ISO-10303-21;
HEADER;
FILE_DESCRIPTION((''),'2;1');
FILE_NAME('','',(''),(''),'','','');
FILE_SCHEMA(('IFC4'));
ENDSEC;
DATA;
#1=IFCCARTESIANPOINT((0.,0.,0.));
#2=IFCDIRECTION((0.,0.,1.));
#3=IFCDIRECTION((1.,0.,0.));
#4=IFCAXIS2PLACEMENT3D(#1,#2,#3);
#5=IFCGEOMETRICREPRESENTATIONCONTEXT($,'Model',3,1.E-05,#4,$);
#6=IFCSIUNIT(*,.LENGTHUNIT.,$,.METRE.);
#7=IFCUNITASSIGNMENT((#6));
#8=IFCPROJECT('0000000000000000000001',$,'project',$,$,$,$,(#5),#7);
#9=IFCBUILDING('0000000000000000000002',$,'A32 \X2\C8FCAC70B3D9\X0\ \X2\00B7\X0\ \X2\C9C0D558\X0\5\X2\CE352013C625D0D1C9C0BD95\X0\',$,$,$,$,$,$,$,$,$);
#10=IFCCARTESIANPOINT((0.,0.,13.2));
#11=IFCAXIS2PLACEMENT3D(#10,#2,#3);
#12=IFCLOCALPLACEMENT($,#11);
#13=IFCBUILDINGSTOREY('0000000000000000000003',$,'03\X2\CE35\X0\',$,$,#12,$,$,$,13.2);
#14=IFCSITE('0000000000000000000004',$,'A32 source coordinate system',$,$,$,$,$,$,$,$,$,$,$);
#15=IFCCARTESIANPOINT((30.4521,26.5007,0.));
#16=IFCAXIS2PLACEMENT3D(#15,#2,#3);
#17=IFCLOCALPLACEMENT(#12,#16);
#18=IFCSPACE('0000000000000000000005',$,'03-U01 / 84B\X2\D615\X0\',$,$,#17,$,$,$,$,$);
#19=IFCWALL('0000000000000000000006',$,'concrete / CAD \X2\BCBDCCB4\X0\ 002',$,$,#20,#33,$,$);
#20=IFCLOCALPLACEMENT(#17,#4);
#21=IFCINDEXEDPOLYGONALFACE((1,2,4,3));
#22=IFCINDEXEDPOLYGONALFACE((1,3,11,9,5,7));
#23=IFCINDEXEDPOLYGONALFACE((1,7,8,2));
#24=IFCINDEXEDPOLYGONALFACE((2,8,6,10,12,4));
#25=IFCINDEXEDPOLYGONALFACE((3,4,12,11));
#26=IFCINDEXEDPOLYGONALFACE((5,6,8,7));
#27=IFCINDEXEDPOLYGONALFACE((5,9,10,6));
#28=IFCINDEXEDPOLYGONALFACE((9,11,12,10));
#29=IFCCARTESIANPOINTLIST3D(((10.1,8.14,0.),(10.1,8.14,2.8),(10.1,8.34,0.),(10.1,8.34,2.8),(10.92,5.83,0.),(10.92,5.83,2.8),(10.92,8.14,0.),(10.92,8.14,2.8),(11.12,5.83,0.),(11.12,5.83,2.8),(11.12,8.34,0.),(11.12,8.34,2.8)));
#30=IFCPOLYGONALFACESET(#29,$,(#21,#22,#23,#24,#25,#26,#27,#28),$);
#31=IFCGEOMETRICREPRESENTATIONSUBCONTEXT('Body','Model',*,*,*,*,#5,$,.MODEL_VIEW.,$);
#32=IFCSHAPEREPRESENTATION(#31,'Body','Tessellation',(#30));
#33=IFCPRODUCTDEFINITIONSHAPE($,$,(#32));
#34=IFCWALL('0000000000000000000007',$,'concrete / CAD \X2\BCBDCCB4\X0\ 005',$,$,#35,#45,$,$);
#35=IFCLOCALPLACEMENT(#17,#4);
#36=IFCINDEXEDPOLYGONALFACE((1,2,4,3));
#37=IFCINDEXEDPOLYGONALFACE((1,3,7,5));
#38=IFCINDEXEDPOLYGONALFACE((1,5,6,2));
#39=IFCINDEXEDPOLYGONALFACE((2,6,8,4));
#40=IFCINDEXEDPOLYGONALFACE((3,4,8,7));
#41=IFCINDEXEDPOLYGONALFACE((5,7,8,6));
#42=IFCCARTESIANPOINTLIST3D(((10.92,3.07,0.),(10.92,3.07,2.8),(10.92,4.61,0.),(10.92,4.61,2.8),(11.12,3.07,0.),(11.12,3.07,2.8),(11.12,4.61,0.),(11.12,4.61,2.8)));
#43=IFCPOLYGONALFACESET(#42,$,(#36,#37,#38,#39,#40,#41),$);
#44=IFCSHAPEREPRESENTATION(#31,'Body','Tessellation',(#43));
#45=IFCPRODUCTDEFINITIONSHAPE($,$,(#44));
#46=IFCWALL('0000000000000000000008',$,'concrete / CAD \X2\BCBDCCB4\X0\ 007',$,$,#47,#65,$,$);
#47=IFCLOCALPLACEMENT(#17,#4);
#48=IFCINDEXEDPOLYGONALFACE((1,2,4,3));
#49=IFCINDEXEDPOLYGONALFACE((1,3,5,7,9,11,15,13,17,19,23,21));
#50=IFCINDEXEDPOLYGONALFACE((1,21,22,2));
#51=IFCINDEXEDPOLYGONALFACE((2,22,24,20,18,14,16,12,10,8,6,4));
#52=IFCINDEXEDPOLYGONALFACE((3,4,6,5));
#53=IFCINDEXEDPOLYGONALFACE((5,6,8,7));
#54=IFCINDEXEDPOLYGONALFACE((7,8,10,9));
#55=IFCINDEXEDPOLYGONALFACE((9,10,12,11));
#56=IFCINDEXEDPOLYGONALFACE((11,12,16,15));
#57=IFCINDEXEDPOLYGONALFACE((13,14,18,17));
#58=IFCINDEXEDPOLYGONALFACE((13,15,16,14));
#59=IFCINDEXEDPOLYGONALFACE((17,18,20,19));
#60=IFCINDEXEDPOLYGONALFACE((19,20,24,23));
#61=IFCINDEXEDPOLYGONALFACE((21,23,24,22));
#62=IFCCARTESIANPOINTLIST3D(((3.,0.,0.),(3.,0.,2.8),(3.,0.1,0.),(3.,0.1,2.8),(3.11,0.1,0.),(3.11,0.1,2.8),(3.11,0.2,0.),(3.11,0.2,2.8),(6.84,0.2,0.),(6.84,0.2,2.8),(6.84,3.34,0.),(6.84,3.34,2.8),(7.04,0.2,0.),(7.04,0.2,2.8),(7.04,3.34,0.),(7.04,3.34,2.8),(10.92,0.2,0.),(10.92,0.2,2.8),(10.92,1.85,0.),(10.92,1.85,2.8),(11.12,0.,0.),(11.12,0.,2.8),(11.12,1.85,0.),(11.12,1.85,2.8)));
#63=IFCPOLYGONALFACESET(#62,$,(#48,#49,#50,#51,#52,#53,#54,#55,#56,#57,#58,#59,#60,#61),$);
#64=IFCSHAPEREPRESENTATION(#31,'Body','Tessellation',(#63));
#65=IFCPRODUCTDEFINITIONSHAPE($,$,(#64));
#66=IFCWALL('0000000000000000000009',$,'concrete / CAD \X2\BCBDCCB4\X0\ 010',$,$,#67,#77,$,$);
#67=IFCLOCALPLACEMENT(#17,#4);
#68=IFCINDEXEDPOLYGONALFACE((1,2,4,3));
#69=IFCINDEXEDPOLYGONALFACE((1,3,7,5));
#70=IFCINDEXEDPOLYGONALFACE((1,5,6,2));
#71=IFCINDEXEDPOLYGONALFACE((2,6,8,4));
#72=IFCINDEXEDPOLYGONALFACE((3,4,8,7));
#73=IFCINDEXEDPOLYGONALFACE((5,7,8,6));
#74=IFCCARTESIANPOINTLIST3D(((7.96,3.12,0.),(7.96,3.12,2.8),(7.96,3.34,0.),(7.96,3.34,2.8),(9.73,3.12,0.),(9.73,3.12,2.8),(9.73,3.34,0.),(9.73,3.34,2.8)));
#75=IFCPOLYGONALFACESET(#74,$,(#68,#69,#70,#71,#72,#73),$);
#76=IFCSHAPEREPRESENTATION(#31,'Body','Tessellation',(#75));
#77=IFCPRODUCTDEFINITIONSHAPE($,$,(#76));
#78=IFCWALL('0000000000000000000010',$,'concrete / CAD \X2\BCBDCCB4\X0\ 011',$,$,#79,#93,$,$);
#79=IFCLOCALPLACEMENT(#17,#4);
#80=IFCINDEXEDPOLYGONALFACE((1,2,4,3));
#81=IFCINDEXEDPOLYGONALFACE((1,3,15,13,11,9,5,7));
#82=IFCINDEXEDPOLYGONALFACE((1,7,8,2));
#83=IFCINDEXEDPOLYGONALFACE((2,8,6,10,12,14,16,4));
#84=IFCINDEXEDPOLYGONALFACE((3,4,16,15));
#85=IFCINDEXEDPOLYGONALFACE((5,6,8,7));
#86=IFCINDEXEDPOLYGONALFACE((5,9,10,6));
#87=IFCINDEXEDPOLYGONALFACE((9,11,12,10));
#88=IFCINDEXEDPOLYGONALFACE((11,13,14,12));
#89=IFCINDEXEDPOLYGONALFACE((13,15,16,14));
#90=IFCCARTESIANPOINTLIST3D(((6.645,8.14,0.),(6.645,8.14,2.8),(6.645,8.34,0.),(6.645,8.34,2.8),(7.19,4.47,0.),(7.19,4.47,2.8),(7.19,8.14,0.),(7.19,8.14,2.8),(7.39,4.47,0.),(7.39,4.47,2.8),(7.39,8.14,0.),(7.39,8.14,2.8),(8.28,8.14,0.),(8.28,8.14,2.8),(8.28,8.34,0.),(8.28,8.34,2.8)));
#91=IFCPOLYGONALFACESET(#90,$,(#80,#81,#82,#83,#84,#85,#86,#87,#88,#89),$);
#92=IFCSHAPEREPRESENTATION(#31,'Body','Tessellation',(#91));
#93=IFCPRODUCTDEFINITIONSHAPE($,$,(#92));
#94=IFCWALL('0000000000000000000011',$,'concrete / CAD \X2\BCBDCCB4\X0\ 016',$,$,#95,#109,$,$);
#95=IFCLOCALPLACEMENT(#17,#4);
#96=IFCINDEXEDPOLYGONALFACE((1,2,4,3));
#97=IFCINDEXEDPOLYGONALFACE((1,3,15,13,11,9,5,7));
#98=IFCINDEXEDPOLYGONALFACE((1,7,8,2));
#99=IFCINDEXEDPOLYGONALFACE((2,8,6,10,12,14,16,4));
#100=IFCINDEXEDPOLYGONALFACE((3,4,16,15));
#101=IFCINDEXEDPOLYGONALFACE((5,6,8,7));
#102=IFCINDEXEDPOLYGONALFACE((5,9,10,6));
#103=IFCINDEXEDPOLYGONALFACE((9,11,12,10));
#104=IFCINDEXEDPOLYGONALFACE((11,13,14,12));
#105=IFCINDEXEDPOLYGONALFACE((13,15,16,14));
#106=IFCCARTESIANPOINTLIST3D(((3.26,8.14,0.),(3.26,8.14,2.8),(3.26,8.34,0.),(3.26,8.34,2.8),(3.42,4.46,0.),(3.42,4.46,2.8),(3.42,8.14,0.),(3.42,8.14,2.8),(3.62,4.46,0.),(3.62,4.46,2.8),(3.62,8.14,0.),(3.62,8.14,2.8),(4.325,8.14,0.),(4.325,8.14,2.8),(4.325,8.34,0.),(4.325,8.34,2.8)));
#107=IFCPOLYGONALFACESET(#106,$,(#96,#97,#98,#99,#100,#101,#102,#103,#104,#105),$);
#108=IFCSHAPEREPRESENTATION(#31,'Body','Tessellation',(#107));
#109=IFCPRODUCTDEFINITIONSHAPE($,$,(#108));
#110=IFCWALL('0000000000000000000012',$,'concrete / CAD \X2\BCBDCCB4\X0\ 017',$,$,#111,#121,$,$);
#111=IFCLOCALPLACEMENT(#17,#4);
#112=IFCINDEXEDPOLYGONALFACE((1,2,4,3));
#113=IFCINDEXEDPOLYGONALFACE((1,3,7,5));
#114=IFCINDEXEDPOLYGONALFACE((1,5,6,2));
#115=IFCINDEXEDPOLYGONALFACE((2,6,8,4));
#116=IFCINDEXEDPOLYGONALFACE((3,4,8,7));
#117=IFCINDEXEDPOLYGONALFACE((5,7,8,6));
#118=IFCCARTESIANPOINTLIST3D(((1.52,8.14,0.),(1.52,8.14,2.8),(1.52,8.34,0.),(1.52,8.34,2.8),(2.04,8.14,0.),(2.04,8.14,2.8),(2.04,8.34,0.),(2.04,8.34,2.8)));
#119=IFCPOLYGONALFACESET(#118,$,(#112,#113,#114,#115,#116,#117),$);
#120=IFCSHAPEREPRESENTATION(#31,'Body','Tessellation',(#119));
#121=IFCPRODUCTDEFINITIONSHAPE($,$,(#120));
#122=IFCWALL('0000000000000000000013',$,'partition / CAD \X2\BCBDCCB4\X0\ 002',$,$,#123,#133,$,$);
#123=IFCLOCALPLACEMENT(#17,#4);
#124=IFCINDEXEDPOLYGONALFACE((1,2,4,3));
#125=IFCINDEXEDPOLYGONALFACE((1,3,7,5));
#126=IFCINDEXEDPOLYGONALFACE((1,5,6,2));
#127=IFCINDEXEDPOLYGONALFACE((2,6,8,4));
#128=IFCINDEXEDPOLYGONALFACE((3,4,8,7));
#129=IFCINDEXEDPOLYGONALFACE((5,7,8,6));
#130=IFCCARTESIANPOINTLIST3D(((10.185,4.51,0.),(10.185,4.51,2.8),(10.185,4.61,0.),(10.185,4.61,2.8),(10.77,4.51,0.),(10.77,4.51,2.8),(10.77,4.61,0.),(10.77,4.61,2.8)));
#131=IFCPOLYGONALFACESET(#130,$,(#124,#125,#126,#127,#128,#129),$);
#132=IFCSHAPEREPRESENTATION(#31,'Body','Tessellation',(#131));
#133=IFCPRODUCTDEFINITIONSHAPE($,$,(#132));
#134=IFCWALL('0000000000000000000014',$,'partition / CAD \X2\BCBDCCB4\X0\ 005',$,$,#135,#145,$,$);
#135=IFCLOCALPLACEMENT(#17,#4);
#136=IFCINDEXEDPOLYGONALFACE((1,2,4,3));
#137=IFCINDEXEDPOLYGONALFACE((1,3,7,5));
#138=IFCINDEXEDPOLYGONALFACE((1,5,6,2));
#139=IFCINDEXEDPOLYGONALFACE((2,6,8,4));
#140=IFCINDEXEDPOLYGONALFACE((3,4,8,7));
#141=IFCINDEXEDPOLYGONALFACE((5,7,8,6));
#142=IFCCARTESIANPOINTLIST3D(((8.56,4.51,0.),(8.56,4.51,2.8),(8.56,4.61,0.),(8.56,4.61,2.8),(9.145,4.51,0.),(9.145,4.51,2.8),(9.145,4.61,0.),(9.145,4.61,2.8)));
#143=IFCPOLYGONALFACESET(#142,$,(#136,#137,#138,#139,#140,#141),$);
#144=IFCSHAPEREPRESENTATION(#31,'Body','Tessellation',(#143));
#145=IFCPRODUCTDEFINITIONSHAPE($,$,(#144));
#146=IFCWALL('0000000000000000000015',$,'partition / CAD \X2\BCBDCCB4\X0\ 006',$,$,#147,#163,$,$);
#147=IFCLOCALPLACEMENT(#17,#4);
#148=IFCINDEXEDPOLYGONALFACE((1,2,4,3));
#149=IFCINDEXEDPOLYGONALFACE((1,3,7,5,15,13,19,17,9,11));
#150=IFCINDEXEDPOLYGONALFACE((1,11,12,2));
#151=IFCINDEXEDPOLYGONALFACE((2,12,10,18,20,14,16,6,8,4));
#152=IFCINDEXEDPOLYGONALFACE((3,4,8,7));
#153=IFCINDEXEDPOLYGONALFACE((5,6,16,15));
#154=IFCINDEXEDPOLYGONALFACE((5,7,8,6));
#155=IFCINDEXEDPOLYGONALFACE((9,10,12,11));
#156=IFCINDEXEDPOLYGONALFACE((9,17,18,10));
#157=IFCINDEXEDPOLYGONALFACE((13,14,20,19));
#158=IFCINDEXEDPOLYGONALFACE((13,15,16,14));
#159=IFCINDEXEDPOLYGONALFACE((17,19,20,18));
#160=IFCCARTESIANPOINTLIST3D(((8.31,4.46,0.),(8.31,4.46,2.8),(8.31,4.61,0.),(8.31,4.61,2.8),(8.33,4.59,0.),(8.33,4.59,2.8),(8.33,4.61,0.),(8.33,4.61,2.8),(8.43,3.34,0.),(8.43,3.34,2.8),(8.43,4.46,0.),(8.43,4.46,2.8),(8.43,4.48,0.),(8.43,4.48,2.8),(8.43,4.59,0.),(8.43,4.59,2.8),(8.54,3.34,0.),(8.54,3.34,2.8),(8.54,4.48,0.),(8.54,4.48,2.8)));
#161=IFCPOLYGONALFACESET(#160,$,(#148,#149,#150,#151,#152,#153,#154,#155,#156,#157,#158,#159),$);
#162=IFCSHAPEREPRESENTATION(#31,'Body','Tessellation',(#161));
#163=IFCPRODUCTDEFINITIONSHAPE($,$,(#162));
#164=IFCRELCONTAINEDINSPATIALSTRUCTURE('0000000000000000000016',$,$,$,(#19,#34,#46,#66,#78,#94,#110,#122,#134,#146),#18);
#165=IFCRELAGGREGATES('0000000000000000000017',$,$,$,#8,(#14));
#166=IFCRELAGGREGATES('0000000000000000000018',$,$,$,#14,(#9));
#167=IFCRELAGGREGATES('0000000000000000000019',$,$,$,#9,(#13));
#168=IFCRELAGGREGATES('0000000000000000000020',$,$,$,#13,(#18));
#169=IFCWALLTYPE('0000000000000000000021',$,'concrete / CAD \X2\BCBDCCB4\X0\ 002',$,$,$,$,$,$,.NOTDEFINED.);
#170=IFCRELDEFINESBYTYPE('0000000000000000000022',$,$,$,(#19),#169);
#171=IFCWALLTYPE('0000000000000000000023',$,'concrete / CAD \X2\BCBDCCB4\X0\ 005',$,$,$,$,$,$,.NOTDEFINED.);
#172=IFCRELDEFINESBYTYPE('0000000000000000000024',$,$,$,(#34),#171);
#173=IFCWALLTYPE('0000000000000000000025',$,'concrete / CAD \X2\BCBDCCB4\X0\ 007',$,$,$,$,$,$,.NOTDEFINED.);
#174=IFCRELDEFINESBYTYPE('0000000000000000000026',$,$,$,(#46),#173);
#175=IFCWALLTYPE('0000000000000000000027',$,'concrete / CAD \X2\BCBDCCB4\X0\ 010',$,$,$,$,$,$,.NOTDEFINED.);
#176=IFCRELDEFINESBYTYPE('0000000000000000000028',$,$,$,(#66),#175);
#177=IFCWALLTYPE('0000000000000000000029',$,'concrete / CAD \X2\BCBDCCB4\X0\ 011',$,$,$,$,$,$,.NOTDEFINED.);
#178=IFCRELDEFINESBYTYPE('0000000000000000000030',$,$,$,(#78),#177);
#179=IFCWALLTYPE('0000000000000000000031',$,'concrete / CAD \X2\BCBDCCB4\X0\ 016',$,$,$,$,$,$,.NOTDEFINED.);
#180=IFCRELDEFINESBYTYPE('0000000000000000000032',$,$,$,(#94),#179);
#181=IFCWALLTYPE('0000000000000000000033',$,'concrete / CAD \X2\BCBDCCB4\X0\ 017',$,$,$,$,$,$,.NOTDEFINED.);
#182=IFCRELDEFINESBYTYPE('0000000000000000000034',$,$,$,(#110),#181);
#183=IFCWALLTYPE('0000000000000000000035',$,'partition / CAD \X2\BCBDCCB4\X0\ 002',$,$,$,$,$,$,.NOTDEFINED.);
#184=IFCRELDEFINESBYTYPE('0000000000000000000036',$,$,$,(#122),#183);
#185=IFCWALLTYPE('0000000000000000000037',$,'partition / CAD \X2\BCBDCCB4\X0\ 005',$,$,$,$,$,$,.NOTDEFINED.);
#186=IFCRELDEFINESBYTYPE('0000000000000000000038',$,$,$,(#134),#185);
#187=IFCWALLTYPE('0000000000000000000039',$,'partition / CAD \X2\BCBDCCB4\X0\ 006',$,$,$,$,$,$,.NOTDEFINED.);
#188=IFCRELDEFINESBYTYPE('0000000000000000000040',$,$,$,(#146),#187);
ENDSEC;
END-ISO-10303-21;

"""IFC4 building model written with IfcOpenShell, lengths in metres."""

from ifc_helpers import new_model, si_unit, frame, origin, origin_with_axes, place, context, subcontext, project, spatial, polyline, outline, extrude, source, transform, mapped, type_object, type_shapes, element, save


model = new_model("IFC4")

# Units and contexts
model_context = context("Model", 3, precision=1e-05, world=origin_with_axes())
body_context = subcontext(model_context, "Body", "Model", "MODEL_VIEW")
ifc_project = project(units=[si_unit("LENGTHUNIT", "METRE")], contexts=[model_context])

# Site, building, storey, space
storey_placement = place(None, frame((0.0, 0.0, 13.2), z_axis=(0.0, 0.0, 1.0), x_axis=(1.0, 0.0, 0.0)))
space_1_placement = place(storey_placement, frame((30.4521, 26.5007, 0.0), z_axis=(0.0, 0.0, 1.0), x_axis=(1.0, 0.0, 0.0)))
site = spatial("IfcSite", under=ifc_project, Name="A32 source coordinate system")
building = spatial("IfcBuilding", under=site, Name="A32 주거동 · 지하5층–옥탑지붕")
storey = spatial("IfcBuildingStorey", under=building, at=storey_placement, Name="03층", Elevation=13.2)
space_1 = spatial("IfcSpace", under=storey, at=space_1_placement, Name="03-U01 / 84B형")

# Walls
wall_type_1 = type_object("IfcWallType", Name="concrete / CAD 벽체 002", PredefinedType="NOTDEFINED")
shared_shape_1 = source(origin(), body_context, "Body", "SweptSolid", [
    extrude(outline(polyline([(11.12, 5.83), (10.92, 5.83), (10.92, 8.14), (10.1, 8.14), (10.1, 8.34), (11.12, 8.34), (11.12, 5.83)])), origin(), (0.0, 0.0, 1.0), 2.8),
])
type_shapes(wall_type_1, [shared_shape_1])
wall_1_placement = place(space_1_placement, origin_with_axes())
element("IfcWall", 1, at=wall_1_placement, inside=space_1, type_object=wall_type_1, Name="concrete / CAD 벽체 002", context=body_context, shape_type="MappedRepresentation", body=[
    mapped(shared_shape_1, transform((0.0, 0.0, 0.0), scale=1.0)),
])
wall_type_2 = type_object("IfcWallType", Name="concrete / CAD 벽체 005", PredefinedType="NOTDEFINED")
shared_shape_2 = source(origin(), body_context, "Body", "SweptSolid", [
    extrude(outline(polyline([(11.12, 3.07), (10.92, 3.07), (10.92, 4.61), (11.12, 4.61), (11.12, 3.07)])), origin(), (0.0, 0.0, 1.0), 2.8),
])
type_shapes(wall_type_2, [shared_shape_2])
wall_2_placement = place(space_1_placement, origin_with_axes())
element("IfcWall", 2, at=wall_2_placement, inside=space_1, type_object=wall_type_2, Name="concrete / CAD 벽체 005", context=body_context, shape_type="MappedRepresentation", body=[
    mapped(shared_shape_2, transform((0.0, 0.0, 0.0), scale=1.0)),
])
wall_type_3 = type_object("IfcWallType", Name="concrete / CAD 벽체 007", PredefinedType="NOTDEFINED")
shared_shape_3 = source(origin(), body_context, "Body", "SweptSolid", [
    extrude(outline(polyline([(3.0, 0.0), (3.0, 0.1), (3.11, 0.1), (3.11, 0.2), (6.84, 0.2), (6.84, 3.34), (7.04, 3.34), (7.04, 0.2), (10.92, 0.2), (10.92, 1.85), (11.12, 1.85), (11.12, 0.0), (3.0, 0.0)])), origin(), (0.0, 0.0, 1.0), 2.8),
])
type_shapes(wall_type_3, [shared_shape_3])
wall_3_placement = place(space_1_placement, origin_with_axes())
element("IfcWall", 3, at=wall_3_placement, inside=space_1, type_object=wall_type_3, Name="concrete / CAD 벽체 007", context=body_context, shape_type="MappedRepresentation", body=[
    mapped(shared_shape_3, transform((0.0, 0.0, 0.0), scale=1.0)),
])
wall_type_4 = type_object("IfcWallType", Name="concrete / CAD 벽체 010", PredefinedType="NOTDEFINED")
shared_shape_4 = source(origin(), body_context, "Body", "SweptSolid", [
    extrude(outline(polyline([(7.96, 3.12), (7.96, 3.34), (9.73, 3.34), (9.73, 3.12), (7.96, 3.12)])), origin(), (0.0, 0.0, 1.0), 2.8),
])
type_shapes(wall_type_4, [shared_shape_4])
wall_4_placement = place(space_1_placement, origin_with_axes())
element("IfcWall", 4, at=wall_4_placement, inside=space_1, type_object=wall_type_4, Name="concrete / CAD 벽체 010", context=body_context, shape_type="MappedRepresentation", body=[
    mapped(shared_shape_4, transform((0.0, 0.0, 0.0), scale=1.0)),
])
wall_type_5 = type_object("IfcWallType", Name="concrete / CAD 벽체 011", PredefinedType="NOTDEFINED")
shared_shape_5 = source(origin(), body_context, "Body", "SweptSolid", [
    extrude(outline(polyline([(7.19, 8.14), (6.645, 8.14), (6.645, 8.34), (8.28, 8.34), (8.28, 8.14), (7.39, 8.14), (7.39, 4.47), (7.19, 4.47), (7.19, 8.14)])), origin(), (0.0, 0.0, 1.0), 2.8),
])
type_shapes(wall_type_5, [shared_shape_5])
wall_5_placement = place(space_1_placement, origin_with_axes())
element("IfcWall", 5, at=wall_5_placement, inside=space_1, type_object=wall_type_5, Name="concrete / CAD 벽체 011", context=body_context, shape_type="MappedRepresentation", body=[
    mapped(shared_shape_5, transform((0.0, 0.0, 0.0), scale=1.0)),
])
wall_type_6 = type_object("IfcWallType", Name="concrete / CAD 벽체 016", PredefinedType="NOTDEFINED")
shared_shape_6 = source(origin(), body_context, "Body", "SweptSolid", [
    extrude(outline(polyline([(3.26, 8.14), (3.26, 8.34), (4.325, 8.34), (4.325, 8.14), (3.62, 8.14), (3.62, 4.46), (3.42, 4.46), (3.42, 8.14), (3.26, 8.14)])), origin(), (0.0, 0.0, 1.0), 2.8),
])
type_shapes(wall_type_6, [shared_shape_6])
wall_6_placement = place(space_1_placement, origin_with_axes())
element("IfcWall", 6, at=wall_6_placement, inside=space_1, type_object=wall_type_6, Name="concrete / CAD 벽체 016", context=body_context, shape_type="MappedRepresentation", body=[
    mapped(shared_shape_6, transform((0.0, 0.0, 0.0), scale=1.0)),
])
wall_type_7 = type_object("IfcWallType", Name="concrete / CAD 벽체 017", PredefinedType="NOTDEFINED")
shared_shape_7 = source(origin(), body_context, "Body", "SweptSolid", [
    extrude(outline(polyline([(1.52, 8.34), (2.04, 8.34), (2.04, 8.14), (1.52, 8.14), (1.52, 8.34)])), origin(), (0.0, 0.0, 1.0), 2.8),
])
type_shapes(wall_type_7, [shared_shape_7])
wall_7_placement = place(space_1_placement, origin_with_axes())
element("IfcWall", 7, at=wall_7_placement, inside=space_1, type_object=wall_type_7, Name="concrete / CAD 벽체 017", context=body_context, shape_type="MappedRepresentation", body=[
    mapped(shared_shape_7, transform((0.0, 0.0, 0.0), scale=1.0)),
])
wall_type_8 = type_object("IfcWallType", Name="partition / CAD 벽체 002", PredefinedType="NOTDEFINED")
shared_shape_8 = source(origin(), body_context, "Body", "SweptSolid", [
    extrude(outline(polyline([(10.185, 4.51), (10.185, 4.61), (10.77, 4.61), (10.77, 4.51), (10.185, 4.51)])), origin(), (0.0, 0.0, 1.0), 2.8),
])
type_shapes(wall_type_8, [shared_shape_8])
wall_8_placement = place(space_1_placement, origin_with_axes())
element("IfcWall", 8, at=wall_8_placement, inside=space_1, type_object=wall_type_8, Name="partition / CAD 벽체 002", context=body_context, shape_type="MappedRepresentation", body=[
    mapped(shared_shape_8, transform((0.0, 0.0, 0.0), scale=1.0)),
])
wall_type_9 = type_object("IfcWallType", Name="partition / CAD 벽체 005", PredefinedType="NOTDEFINED")
shared_shape_9 = source(origin(), body_context, "Body", "SweptSolid", [
    extrude(outline(polyline([(8.56, 4.51), (8.56, 4.61), (9.145, 4.61), (9.145, 4.51), (8.56, 4.51)])), origin(), (0.0, 0.0, 1.0), 2.8),
])
type_shapes(wall_type_9, [shared_shape_9])
wall_9_placement = place(space_1_placement, origin_with_axes())
element("IfcWall", 9, at=wall_9_placement, inside=space_1, type_object=wall_type_9, Name="partition / CAD 벽체 005", context=body_context, shape_type="MappedRepresentation", body=[
    mapped(shared_shape_9, transform((0.0, 0.0, 0.0), scale=1.0)),
])
wall_type_10 = type_object("IfcWallType", Name="partition / CAD 벽체 006", PredefinedType="NOTDEFINED")
shared_shape_10 = source(origin(), body_context, "Body", "SweptSolid", [
    extrude(outline(polyline([(8.43, 4.46), (8.31, 4.46), (8.31, 4.61), (8.33, 4.61), (8.33, 4.59), (8.43, 4.59), (8.43, 4.48), (8.54, 4.48), (8.54, 3.34), (8.43, 3.34), (8.43, 4.46)])), origin(), (0.0, 0.0, 1.0), 2.8),
])
type_shapes(wall_type_10, [shared_shape_10])
wall_10_placement = place(space_1_placement, origin_with_axes())
element("IfcWall", 10, at=wall_10_placement, inside=space_1, type_object=wall_type_10, Name="partition / CAD 벽체 006", context=body_context, shape_type="MappedRepresentation", body=[
    mapped(shared_shape_10, transform((0.0, 0.0, 0.0), scale=1.0)),
])

save(model, "model.ifc")
